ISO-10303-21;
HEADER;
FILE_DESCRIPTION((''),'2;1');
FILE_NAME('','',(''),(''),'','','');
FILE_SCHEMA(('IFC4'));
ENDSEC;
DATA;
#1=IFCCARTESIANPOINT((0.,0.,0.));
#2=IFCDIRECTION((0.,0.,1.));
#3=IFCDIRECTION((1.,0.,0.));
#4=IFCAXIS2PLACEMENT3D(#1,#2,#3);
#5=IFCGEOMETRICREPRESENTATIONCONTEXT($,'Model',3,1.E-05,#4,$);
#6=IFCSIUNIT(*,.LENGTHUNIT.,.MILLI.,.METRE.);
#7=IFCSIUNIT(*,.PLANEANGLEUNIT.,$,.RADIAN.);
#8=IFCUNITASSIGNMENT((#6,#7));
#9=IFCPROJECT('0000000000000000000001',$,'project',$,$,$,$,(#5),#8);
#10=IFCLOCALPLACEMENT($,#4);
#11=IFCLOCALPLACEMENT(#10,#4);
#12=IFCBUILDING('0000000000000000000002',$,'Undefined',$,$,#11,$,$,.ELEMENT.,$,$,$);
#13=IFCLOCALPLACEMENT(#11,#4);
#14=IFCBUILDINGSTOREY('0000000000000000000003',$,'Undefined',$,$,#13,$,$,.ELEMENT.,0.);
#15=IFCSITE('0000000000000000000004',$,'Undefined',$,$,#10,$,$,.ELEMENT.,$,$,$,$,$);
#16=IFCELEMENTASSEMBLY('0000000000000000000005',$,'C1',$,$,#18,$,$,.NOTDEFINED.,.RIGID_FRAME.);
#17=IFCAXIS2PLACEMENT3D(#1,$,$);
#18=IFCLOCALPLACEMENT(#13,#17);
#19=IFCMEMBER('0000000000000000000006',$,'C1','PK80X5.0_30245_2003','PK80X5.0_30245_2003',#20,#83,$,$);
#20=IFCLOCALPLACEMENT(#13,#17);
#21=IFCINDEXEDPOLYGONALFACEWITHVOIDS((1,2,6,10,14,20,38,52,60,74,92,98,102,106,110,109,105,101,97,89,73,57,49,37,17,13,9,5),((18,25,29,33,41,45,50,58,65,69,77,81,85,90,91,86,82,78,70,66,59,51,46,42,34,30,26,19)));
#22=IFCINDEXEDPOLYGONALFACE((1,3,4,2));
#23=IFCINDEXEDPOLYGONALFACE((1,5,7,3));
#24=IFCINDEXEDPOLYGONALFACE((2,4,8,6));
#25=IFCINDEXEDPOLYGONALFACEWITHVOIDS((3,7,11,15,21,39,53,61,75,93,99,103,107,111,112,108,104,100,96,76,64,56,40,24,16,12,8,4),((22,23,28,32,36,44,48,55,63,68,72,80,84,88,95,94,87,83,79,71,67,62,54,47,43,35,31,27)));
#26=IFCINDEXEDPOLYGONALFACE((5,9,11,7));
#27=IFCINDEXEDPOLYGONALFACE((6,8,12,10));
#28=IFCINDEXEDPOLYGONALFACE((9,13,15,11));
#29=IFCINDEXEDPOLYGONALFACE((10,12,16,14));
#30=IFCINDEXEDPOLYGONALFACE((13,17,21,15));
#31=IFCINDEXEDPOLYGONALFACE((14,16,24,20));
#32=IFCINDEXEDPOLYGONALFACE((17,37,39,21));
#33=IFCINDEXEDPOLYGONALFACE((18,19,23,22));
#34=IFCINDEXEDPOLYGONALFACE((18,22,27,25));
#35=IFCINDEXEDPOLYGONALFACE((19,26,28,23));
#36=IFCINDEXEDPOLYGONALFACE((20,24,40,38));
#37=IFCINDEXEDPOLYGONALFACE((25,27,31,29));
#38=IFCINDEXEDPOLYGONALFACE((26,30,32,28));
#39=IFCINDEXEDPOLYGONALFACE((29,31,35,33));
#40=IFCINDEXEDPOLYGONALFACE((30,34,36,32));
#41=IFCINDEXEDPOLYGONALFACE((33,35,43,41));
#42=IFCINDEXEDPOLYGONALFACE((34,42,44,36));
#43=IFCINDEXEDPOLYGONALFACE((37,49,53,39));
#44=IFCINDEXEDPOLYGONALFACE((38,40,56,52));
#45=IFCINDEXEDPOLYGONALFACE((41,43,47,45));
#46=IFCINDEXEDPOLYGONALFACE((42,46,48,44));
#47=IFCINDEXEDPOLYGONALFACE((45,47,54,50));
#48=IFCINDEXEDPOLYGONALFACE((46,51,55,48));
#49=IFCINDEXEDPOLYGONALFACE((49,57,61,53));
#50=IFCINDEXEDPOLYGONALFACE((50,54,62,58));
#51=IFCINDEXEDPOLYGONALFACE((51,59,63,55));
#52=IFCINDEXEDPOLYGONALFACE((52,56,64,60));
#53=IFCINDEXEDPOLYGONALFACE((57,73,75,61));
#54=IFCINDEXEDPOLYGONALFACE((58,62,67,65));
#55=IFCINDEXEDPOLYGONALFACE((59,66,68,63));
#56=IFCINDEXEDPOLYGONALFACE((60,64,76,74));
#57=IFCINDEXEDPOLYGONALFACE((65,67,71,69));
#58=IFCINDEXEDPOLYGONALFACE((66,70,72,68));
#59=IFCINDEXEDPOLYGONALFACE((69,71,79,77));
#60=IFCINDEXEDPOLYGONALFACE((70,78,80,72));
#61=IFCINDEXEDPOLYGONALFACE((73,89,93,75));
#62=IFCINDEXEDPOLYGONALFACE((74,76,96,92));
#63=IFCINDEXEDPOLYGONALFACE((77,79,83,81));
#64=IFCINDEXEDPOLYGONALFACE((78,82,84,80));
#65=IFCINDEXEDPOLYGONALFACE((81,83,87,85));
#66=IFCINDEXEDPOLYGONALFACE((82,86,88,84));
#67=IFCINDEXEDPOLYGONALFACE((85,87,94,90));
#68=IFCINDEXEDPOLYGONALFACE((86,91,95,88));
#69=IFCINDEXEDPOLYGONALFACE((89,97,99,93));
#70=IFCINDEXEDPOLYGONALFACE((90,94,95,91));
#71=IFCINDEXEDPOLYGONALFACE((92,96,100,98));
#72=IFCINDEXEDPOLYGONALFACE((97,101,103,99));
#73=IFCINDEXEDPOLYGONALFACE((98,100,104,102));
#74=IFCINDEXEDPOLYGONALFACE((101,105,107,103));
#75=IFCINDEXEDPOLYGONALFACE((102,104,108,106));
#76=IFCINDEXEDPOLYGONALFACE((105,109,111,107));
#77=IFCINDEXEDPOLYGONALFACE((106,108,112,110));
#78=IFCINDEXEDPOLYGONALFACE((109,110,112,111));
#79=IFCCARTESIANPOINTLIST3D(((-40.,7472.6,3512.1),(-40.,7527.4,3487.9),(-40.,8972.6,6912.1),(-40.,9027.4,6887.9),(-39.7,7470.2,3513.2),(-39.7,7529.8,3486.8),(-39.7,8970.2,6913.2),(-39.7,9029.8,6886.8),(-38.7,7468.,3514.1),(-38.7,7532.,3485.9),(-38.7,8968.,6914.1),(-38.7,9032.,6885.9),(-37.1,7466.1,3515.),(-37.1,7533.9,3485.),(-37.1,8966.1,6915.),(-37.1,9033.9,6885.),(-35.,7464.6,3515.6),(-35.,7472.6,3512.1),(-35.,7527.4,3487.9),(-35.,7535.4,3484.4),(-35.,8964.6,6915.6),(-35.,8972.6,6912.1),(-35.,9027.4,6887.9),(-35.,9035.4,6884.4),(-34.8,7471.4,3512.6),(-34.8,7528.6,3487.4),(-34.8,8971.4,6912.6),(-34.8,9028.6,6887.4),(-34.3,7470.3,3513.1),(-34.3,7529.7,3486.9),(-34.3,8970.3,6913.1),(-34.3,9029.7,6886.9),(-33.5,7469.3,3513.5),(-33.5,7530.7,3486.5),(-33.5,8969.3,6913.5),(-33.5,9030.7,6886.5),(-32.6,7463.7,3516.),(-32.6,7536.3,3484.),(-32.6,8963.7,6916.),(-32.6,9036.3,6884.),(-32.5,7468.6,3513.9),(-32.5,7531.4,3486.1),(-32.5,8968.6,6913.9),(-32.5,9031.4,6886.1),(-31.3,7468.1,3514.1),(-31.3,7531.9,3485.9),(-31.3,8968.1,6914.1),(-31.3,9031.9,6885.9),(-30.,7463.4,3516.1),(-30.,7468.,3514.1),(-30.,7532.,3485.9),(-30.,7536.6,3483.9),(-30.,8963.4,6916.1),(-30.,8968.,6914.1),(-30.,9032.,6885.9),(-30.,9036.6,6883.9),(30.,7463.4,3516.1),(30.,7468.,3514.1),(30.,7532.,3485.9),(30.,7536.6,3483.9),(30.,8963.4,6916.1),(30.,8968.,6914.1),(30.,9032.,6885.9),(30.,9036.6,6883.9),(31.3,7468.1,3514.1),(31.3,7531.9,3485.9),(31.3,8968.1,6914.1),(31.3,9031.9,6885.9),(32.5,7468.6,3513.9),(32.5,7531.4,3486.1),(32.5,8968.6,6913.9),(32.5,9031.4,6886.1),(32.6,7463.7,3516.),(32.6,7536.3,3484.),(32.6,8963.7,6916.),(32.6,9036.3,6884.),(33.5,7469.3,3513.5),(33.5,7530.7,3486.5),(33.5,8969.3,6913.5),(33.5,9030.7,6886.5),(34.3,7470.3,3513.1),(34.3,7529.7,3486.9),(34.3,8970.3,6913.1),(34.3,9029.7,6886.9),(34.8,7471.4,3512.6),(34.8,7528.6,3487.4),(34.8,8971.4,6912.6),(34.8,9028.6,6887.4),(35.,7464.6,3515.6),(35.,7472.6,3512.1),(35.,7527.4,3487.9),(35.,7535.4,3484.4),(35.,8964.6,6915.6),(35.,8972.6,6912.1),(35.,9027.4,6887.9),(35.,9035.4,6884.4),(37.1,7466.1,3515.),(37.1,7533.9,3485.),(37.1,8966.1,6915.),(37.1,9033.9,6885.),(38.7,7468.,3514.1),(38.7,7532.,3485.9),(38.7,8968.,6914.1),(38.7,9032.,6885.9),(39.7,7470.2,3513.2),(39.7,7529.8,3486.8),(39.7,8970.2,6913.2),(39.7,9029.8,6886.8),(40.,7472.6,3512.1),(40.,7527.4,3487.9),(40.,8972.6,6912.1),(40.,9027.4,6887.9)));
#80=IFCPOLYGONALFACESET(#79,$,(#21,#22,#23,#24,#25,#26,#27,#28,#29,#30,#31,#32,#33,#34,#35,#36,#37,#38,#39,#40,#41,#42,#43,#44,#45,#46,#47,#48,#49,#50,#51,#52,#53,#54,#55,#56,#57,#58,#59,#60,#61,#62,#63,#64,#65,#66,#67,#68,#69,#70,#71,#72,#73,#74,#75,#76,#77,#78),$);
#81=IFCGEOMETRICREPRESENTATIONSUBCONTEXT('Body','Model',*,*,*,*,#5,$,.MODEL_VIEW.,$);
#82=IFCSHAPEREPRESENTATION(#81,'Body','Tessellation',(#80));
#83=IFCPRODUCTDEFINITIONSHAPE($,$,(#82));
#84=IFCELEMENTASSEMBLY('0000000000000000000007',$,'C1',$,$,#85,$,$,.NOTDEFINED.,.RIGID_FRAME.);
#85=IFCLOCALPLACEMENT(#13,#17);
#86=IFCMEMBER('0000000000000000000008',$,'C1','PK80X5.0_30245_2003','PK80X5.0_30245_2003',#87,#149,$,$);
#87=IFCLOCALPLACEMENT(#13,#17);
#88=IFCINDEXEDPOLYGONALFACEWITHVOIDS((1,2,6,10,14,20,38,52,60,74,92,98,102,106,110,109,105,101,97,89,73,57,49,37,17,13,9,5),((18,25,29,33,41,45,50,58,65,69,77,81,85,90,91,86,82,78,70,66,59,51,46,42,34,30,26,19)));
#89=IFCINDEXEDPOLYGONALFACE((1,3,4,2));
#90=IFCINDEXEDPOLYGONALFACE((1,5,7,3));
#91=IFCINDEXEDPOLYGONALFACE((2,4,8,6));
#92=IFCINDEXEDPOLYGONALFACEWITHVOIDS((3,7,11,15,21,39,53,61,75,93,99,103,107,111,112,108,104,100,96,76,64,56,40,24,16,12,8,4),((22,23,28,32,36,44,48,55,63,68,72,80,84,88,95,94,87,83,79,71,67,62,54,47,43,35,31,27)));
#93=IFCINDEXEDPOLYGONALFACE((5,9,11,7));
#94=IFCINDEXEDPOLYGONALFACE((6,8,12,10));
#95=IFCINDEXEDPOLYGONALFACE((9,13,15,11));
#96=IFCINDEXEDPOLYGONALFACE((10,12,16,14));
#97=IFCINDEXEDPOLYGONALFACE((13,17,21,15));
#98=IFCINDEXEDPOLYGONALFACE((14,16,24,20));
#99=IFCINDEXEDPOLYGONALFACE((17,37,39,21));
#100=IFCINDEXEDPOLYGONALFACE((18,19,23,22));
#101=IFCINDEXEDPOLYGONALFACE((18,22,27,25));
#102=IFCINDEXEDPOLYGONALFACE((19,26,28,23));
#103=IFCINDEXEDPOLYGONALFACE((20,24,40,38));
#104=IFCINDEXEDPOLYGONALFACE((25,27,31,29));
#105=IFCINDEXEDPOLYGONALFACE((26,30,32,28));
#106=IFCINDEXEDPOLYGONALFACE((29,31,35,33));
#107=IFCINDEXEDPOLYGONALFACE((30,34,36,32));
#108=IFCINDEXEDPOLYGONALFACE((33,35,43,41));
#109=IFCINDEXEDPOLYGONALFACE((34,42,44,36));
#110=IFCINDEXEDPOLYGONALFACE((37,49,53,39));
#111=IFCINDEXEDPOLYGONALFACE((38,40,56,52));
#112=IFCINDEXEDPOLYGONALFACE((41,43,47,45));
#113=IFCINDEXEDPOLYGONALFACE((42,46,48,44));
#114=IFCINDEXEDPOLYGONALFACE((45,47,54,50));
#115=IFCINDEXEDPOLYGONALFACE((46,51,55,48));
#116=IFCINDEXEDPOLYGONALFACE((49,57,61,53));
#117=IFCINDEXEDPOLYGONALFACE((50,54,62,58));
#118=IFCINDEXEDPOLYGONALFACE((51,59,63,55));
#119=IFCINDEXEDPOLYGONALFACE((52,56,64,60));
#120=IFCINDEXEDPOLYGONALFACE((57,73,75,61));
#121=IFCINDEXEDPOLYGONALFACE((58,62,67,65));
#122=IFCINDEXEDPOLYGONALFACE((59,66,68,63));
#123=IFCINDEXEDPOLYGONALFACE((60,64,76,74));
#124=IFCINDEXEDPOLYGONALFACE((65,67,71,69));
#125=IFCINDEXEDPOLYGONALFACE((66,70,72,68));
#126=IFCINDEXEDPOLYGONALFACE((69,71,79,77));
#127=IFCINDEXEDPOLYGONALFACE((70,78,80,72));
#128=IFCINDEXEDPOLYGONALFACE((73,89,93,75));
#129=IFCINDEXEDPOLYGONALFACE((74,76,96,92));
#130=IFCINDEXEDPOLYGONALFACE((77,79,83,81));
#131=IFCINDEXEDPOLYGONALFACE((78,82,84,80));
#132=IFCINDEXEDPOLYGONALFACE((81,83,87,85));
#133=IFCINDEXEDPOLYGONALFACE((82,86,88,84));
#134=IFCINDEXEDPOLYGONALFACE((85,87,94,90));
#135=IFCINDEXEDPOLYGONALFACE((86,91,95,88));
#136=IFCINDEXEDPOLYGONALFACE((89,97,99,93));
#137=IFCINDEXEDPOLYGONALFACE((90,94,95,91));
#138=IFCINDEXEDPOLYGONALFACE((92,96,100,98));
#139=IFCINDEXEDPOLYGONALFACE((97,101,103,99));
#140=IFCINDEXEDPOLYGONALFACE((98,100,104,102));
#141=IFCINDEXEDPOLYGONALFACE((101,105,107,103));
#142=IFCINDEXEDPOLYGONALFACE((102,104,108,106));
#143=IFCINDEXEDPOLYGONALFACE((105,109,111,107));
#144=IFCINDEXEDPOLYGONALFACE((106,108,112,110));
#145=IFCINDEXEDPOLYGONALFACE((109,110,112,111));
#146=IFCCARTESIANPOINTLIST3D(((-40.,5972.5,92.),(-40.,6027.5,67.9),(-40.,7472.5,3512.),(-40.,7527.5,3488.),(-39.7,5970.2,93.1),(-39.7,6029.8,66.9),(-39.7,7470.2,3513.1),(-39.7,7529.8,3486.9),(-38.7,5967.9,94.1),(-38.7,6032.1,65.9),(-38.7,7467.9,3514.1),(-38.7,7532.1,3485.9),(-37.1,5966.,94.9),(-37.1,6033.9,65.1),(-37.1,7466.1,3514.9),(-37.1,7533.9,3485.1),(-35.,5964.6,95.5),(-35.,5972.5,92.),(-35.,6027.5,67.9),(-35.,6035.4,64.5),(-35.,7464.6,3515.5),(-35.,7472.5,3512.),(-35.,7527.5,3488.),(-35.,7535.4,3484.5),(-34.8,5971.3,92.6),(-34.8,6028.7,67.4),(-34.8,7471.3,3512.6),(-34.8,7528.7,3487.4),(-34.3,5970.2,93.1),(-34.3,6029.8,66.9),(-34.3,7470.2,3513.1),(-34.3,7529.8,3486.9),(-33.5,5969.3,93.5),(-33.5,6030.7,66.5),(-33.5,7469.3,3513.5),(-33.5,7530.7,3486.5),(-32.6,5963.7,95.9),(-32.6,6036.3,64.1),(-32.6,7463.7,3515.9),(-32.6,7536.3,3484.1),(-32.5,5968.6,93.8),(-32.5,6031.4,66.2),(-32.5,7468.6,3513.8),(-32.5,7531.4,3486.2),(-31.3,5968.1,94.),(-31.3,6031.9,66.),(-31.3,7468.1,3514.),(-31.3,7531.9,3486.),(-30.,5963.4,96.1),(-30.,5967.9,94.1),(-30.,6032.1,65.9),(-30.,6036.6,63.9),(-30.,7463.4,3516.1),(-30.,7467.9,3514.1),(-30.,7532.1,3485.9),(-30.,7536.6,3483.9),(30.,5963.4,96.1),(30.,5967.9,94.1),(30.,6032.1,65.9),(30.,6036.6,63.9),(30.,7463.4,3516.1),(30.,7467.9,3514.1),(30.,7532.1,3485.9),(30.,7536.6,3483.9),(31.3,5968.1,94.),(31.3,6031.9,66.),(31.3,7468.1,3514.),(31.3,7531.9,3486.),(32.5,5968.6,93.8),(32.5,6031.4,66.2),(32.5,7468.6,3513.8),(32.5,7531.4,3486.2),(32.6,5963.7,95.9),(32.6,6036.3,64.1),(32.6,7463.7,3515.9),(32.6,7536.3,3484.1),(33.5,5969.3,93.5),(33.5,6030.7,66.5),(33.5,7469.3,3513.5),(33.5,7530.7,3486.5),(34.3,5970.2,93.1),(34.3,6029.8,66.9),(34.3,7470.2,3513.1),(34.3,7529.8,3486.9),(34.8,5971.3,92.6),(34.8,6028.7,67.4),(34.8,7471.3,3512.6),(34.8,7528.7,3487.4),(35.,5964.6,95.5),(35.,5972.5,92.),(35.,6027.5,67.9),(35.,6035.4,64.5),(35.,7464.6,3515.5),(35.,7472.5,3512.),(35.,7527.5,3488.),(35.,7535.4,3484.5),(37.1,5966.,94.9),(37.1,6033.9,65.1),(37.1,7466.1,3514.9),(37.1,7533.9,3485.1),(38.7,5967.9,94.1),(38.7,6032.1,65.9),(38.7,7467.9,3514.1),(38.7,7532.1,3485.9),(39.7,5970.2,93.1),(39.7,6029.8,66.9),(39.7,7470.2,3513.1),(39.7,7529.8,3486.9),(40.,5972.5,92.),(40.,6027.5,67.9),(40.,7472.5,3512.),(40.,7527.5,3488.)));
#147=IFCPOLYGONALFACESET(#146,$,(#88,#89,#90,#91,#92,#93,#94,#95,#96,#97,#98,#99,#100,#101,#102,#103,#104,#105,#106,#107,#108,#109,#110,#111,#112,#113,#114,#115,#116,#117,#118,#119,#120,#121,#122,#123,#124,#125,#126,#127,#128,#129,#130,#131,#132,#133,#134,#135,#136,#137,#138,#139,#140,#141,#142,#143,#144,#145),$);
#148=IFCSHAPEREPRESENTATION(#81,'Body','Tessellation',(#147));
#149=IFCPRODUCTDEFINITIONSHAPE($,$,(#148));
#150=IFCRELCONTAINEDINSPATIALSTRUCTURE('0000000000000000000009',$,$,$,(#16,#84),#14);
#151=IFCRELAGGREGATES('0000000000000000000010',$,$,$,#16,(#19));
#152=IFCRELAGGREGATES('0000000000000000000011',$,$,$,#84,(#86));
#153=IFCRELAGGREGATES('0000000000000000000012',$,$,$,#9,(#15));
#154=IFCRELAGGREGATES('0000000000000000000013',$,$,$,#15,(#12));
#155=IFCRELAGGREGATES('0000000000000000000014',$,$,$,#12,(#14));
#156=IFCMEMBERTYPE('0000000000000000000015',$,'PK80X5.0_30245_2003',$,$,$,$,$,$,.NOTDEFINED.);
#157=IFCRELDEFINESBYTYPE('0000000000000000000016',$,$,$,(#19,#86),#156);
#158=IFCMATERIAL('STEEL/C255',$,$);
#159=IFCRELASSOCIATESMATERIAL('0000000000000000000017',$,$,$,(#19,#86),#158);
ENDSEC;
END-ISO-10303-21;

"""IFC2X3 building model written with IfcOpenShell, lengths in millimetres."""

from ifc_helpers import new_model, si_unit, frame, origin_with_axes, origin_2d_with_axis, place, context, subcontext, project, spatial, hollow_rectangle, extrude, material, type_object, element, aggregate, save


model = new_model("IFC2X3")

# Units and contexts
model_context = context("Model", 3, precision=1e-05, world=origin_with_axes())
body_context = subcontext(model_context, "Body", "Model", "MODEL_VIEW")
ifc_project = project(units=[si_unit("LENGTHUNIT", "METRE", prefix="MILLI"), si_unit("PLANEANGLEUNIT", "RADIAN")], contexts=[model_context])

# Site, building, storey
site_placement = place(None, origin_with_axes())
site = spatial("IfcSite", under=ifc_project, at=site_placement, Name="Undefined", CompositionType="ELEMENT")
building_placement = place(site_placement, origin_with_axes())
building = spatial("IfcBuilding", under=site, at=building_placement, Name="Undefined", CompositionType="ELEMENT")
storey_placement = place(building_placement, origin_with_axes())
storey = spatial("IfcBuildingStorey", under=building, at=storey_placement, Name="Undefined", CompositionType="ELEMENT", Elevation=0.0)

# Shared definitions
ifc_material_1 = material(Name="STEEL/C255")

# Element assemblies, members
assembly_1_placement = place(storey_placement, origin_with_axes())
assembly_1 = element("IfcElementAssembly", 1, at=assembly_1_placement, inside=storey, Name="C1", AssemblyPlace="NOTDEFINED", PredefinedType="RIGID_FRAME")
member_type = type_object("IfcMemberType", Name="PK80X5.0_30245_2003", PredefinedType="NOTDEFINED")
member_1_placement = place(assembly_1_placement, frame((0.0, 7500.0, 3500.0), z_axis=(0.0, 0.914918, -0.40364), x_axis=(0.0, 0.40364, 0.914918)))
member_1 = element("IfcMember", 2, at=member_1_placement, type_object=member_type, material=ifc_material_1, Name="C1", Description="PK80X5.0_30245_2003", ObjectType="PK80X5.0_30245_2003", context=body_context, shape_type="SweptSolid", body=[
    extrude(hollow_rectangle(XDim=80.0, YDim=80.0, WallThickness=5.0, InnerFilletRadius=5.0, OuterFilletRadius=10.0, at=origin_2d_with_axis()), frame((3716.2, 0.0, 0.0), z_axis=(-1.0, 0.0, 0.0), x_axis=(0.0, -1.0, 0.0)), (0.0, 0.0, 1.0), 3716.2),
])
aggregate(assembly_1, [member_1])
assembly_2_placement = place(storey_placement, origin_with_axes())
assembly_2 = element("IfcElementAssembly", 3, at=assembly_2_placement, inside=storey, Name="C1", AssemblyPlace="NOTDEFINED", PredefinedType="RIGID_FRAME")
member_2_placement = place(assembly_2_placement, frame((0.0, 6000.0, 80.0), z_axis=(0.0, 0.915788, -0.401661), x_axis=(0.0, 0.401661, 0.915788)))
member_2 = element("IfcMember", 4, at=member_2_placement, type_object=member_type, material=ifc_material_1, Name="C1", Description="PK80X5.0_30245_2003", ObjectType="PK80X5.0_30245_2003", context=body_context, shape_type="SweptSolid", body=[
    extrude(hollow_rectangle(XDim=80.0, YDim=80.0, WallThickness=5.0, InnerFilletRadius=5.0, OuterFilletRadius=10.0, at=origin_2d_with_axis()), frame((3734.5, 0.0, 0.0), z_axis=(-1.0, 0.0, 0.0), x_axis=(0.0, -1.0, 0.0)), (0.0, 0.0, 1.0), 3734.5),
])
aggregate(assembly_2, [member_2])

save(model, "model.ifc")
